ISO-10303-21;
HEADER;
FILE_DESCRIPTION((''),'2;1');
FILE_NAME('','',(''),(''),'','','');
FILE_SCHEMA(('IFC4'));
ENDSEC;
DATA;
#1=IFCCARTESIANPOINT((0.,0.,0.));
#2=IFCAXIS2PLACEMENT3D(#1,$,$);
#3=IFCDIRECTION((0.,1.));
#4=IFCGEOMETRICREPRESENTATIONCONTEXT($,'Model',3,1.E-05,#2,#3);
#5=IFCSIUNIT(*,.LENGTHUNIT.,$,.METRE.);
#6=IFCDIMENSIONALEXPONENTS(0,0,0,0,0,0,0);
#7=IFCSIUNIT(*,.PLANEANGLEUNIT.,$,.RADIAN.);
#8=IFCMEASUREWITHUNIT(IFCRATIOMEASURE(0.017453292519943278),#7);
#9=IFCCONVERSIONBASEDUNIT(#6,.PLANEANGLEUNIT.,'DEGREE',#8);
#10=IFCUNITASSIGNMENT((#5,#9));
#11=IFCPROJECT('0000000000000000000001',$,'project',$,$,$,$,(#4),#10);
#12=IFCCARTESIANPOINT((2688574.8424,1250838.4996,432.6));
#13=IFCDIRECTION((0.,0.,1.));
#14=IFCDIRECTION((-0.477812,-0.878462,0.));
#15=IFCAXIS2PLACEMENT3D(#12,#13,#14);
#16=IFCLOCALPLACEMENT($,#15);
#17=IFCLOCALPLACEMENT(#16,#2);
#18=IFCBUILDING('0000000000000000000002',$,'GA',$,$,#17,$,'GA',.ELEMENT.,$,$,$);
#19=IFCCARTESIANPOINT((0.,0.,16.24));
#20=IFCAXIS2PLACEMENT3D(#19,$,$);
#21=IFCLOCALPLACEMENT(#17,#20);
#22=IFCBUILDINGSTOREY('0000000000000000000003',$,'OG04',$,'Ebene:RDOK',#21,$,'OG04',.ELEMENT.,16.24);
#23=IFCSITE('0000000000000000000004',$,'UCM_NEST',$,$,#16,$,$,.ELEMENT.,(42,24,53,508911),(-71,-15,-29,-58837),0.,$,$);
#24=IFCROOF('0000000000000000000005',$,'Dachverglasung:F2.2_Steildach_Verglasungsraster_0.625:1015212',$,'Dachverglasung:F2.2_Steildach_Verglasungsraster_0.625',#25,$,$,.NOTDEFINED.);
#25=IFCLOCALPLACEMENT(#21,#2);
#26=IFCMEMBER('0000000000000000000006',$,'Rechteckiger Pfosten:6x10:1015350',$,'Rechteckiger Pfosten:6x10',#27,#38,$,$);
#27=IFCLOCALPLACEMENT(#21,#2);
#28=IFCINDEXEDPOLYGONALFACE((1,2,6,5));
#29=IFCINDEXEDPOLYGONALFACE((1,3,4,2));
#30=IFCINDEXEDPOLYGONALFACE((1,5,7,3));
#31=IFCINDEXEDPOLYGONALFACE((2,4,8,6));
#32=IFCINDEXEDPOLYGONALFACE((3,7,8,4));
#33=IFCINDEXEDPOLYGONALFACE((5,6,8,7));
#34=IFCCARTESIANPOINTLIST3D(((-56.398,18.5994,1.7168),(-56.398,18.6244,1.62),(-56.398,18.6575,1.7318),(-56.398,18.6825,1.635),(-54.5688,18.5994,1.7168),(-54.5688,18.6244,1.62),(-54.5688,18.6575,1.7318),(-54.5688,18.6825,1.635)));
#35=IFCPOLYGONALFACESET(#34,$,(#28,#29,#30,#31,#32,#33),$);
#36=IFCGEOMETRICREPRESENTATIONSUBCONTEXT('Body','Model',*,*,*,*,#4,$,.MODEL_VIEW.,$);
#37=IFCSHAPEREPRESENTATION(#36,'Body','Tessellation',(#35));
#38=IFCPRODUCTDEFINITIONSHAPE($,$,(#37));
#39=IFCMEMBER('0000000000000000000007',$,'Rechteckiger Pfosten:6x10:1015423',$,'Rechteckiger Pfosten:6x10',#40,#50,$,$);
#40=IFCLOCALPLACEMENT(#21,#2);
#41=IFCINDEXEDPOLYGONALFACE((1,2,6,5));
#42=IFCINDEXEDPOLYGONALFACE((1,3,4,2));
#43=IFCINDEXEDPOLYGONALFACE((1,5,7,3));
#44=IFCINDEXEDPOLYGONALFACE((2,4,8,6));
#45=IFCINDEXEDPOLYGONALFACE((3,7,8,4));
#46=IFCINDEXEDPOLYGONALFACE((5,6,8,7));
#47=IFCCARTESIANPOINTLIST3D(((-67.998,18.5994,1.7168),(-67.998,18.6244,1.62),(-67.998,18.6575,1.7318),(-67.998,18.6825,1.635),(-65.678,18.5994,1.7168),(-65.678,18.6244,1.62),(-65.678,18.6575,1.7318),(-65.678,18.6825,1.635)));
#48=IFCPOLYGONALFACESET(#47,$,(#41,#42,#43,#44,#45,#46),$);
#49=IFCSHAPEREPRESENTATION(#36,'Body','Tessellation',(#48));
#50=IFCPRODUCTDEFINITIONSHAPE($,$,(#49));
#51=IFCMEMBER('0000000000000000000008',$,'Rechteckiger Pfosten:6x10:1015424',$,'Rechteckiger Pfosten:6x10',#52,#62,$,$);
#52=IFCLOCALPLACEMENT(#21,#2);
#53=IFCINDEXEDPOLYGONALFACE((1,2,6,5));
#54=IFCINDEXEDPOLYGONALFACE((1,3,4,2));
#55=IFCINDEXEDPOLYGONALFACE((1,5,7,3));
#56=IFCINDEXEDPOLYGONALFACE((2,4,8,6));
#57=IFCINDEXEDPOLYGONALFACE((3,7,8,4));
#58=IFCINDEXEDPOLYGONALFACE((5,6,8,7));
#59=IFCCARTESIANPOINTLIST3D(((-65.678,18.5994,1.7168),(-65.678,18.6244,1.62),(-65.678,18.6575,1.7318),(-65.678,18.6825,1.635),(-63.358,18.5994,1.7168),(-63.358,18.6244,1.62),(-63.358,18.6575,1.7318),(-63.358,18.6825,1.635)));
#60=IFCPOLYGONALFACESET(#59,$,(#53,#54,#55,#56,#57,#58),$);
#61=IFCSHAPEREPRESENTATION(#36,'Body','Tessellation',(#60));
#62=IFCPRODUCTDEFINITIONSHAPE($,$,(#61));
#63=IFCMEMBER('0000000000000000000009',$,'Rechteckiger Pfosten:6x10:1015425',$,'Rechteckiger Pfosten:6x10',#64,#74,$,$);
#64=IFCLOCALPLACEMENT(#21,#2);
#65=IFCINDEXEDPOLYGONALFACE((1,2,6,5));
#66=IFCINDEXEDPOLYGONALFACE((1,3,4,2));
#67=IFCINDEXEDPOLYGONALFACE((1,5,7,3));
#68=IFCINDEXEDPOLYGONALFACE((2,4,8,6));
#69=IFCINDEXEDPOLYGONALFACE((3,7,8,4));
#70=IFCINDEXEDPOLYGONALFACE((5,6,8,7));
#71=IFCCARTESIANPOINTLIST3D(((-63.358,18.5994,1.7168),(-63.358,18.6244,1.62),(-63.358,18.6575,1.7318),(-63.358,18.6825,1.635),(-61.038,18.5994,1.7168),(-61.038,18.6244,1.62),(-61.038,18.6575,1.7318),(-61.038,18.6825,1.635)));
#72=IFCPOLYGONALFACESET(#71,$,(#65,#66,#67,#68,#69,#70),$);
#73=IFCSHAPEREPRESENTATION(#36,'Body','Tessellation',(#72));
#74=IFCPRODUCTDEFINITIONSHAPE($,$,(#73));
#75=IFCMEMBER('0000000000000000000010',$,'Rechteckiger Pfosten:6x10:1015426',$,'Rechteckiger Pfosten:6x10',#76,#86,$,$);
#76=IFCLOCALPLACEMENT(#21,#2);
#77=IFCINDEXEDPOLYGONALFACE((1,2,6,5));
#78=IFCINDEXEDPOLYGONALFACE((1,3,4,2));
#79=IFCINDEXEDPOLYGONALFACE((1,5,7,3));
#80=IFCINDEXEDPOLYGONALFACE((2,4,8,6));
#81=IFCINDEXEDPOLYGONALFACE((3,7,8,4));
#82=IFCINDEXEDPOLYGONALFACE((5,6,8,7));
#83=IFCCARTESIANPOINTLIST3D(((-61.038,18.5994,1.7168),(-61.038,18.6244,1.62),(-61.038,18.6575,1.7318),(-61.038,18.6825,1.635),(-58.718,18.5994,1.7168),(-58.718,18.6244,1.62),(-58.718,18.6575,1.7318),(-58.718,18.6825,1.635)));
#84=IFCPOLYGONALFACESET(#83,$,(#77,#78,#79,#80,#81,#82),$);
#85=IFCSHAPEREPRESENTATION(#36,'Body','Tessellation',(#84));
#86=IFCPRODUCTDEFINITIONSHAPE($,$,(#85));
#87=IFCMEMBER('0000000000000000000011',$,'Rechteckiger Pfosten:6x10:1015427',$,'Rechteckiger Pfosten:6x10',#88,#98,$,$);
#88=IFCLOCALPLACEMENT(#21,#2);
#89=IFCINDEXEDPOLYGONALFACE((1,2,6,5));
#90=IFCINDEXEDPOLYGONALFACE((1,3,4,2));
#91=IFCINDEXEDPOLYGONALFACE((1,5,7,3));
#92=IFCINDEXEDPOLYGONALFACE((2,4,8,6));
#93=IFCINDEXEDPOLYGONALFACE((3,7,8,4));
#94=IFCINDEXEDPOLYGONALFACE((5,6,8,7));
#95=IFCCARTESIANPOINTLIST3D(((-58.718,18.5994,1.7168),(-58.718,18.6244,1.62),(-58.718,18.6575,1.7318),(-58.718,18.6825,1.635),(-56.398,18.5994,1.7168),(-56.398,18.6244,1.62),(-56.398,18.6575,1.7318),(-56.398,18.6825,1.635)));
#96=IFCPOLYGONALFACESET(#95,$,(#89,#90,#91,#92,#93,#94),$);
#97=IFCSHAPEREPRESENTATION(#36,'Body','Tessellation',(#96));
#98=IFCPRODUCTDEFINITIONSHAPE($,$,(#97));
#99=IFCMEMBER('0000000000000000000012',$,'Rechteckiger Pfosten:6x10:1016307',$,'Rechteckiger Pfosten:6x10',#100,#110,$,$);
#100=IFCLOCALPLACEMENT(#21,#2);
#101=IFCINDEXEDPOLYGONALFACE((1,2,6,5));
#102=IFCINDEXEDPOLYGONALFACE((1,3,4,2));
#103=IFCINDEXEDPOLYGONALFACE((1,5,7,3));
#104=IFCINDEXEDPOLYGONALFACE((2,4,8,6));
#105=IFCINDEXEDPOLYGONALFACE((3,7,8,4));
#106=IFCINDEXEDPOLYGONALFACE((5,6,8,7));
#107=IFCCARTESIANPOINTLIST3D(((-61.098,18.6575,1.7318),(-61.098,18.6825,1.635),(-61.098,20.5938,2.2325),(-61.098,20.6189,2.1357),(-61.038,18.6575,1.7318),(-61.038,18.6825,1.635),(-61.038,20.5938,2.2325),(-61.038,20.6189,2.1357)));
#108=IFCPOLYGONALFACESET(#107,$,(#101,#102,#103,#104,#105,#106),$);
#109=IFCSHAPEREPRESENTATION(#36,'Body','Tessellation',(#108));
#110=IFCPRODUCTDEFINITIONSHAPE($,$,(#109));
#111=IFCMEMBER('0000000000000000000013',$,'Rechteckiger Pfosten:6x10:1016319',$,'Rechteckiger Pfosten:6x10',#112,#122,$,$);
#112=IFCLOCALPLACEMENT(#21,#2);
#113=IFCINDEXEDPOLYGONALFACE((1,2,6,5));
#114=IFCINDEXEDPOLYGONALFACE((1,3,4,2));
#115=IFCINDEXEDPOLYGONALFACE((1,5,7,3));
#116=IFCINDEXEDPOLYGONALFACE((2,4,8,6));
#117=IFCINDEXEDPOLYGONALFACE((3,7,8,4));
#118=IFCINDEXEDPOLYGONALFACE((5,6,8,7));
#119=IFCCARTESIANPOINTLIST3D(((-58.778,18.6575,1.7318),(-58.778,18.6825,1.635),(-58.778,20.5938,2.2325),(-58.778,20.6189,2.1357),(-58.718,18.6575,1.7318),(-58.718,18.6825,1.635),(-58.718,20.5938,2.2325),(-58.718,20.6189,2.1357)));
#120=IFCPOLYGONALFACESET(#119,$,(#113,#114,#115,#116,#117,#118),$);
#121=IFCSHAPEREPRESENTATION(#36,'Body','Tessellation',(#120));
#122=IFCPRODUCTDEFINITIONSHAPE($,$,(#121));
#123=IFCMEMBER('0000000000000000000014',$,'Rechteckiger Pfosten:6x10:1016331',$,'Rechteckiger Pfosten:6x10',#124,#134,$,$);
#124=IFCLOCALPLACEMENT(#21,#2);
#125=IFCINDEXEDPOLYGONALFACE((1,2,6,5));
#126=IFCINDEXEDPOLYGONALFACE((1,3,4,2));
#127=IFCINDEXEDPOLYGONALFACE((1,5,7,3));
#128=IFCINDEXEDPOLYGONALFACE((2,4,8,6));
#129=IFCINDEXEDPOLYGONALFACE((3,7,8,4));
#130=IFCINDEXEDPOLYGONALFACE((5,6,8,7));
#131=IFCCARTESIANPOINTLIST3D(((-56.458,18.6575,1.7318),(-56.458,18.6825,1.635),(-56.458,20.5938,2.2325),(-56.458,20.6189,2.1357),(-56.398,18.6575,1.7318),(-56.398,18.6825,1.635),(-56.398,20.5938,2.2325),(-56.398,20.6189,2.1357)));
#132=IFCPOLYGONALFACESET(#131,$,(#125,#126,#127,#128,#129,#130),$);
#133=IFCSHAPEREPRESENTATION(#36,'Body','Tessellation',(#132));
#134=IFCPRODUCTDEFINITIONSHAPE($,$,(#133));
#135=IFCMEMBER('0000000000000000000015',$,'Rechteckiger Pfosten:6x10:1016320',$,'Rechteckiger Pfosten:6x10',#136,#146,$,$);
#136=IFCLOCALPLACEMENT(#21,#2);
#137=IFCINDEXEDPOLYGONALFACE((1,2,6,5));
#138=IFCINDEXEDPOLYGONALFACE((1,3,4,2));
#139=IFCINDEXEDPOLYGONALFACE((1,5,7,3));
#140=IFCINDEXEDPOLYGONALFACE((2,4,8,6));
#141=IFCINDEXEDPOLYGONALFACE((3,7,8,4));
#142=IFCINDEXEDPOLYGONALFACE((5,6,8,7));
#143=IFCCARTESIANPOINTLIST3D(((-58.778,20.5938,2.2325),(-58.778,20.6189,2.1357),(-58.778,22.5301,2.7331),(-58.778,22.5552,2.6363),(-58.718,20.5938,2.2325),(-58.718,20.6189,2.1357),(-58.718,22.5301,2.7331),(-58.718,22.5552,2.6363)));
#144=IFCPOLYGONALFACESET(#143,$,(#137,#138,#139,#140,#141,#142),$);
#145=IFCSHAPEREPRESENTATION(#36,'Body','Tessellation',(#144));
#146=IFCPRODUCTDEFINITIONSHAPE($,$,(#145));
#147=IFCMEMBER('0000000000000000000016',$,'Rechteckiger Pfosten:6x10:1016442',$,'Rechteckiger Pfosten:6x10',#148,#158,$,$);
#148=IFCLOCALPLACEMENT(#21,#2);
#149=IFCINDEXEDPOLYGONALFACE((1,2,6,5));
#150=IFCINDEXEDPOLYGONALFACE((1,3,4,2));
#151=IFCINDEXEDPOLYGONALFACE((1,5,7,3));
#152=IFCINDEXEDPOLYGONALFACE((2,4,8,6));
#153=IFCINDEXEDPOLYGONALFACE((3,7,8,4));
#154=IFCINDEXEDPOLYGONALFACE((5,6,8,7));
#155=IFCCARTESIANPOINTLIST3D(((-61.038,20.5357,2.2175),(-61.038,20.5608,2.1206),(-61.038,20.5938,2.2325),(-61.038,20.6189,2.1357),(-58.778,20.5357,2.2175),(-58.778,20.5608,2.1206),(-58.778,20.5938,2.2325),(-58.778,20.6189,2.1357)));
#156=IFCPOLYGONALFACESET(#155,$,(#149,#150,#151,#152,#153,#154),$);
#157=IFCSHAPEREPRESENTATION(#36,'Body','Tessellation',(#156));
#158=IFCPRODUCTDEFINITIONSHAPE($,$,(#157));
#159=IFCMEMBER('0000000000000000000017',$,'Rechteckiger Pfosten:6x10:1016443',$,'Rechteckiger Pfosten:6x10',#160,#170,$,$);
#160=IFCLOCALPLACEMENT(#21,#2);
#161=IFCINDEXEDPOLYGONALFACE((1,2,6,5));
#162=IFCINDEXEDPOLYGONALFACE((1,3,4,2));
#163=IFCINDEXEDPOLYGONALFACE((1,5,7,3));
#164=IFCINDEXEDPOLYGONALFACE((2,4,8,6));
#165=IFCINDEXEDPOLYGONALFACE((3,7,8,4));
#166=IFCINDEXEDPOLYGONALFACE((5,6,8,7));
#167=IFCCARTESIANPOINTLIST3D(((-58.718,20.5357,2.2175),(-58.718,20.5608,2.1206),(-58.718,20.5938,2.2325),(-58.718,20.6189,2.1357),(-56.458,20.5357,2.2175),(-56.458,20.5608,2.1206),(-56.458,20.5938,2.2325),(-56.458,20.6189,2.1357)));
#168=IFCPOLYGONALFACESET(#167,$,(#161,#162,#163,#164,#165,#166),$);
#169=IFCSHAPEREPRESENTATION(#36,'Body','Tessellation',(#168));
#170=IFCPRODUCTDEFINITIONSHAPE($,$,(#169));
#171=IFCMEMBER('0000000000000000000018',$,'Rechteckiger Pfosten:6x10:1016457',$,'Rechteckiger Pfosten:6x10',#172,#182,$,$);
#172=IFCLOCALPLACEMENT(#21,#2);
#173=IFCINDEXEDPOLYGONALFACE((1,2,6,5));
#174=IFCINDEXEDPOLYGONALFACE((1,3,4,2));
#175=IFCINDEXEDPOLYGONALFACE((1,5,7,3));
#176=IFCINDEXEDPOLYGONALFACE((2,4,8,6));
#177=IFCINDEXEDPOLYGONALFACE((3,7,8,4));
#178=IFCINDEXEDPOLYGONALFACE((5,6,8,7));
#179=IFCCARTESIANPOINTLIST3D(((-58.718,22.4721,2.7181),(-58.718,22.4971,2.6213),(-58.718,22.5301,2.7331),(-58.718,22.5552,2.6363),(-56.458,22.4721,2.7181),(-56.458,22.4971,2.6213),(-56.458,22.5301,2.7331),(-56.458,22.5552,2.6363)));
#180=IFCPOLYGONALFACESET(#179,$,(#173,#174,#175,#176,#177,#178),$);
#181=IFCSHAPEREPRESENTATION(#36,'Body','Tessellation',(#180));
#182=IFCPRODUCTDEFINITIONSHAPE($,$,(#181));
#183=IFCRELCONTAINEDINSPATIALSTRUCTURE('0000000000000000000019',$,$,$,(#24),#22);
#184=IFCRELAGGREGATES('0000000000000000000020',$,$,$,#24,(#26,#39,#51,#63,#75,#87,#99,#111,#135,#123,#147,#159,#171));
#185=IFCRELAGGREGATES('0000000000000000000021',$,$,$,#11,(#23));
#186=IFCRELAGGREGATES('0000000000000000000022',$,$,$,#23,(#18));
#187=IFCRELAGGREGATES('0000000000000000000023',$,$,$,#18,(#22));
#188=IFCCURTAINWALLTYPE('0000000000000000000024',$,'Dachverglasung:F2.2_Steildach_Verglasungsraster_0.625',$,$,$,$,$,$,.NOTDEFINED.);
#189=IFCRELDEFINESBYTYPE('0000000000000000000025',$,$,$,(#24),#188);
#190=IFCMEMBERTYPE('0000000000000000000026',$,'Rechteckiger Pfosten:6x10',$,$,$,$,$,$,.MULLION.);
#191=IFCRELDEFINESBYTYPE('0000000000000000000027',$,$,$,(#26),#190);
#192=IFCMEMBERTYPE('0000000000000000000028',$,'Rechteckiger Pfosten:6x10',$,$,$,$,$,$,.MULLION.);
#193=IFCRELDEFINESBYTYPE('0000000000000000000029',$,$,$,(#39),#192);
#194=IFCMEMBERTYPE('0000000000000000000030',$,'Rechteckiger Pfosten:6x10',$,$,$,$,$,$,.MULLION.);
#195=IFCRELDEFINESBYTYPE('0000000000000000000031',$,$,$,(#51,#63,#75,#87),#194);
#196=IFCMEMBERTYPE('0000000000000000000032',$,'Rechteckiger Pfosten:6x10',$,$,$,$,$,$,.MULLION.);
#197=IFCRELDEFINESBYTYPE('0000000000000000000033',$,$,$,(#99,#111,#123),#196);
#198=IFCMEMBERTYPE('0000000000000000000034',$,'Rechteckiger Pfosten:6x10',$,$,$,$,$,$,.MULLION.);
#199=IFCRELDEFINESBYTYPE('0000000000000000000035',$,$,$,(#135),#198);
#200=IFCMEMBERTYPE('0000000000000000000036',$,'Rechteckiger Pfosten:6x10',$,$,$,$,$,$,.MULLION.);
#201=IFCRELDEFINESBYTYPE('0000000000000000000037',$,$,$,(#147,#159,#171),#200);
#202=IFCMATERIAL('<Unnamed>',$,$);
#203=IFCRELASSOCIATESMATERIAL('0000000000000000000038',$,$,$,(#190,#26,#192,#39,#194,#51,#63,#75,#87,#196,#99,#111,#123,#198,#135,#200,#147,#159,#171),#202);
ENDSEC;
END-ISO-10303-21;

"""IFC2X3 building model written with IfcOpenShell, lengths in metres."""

from ifc_helpers import new_model, entity, si_unit, converted_unit, direction, frame, origin, origin_2d_with_axis, place, context, subcontext, project, spatial, rectangle, extrude, source, transform, mapped, material, type_object, type_shapes, element, aggregate, save


model = new_model("IFC2X3")

# Units and contexts
model_context = context("Model", 3, precision=1e-05, world=origin(), true_north=direction((0.0, 1.0)))
body_context = subcontext(model_context, "Body", "Model", "MODEL_VIEW")
ifc_project = project(units=[si_unit("LENGTHUNIT", "METRE"), converted_unit("PLANEANGLEUNIT", "DEGREE", entity("IfcRatioMeasure", 0.017453292519943278), si_unit("PLANEANGLEUNIT", "RADIAN"), dimensions=[0, 0, 0, 0, 0, 0, 0])], contexts=[model_context])

# Site, building, storey
site_placement = place(None, frame((2688574.8424, 1250838.4996, 432.6), z_axis=(0.0, 0.0, 1.0), x_axis=(-0.477812, -0.878462, 0.0)))
site = spatial("IfcSite", under=ifc_project, at=site_placement, Name="UCM_NEST", CompositionType="ELEMENT", RefLatitude=(42, 24, 53, 508911), RefLongitude=(-71, -15, -29, -58837), RefElevation=0.0)
building_placement = place(site_placement, origin())
building = spatial("IfcBuilding", under=site, at=building_placement, Name="GA", LongName="GA", CompositionType="ELEMENT")
storey_placement = place(building_placement, frame((0.0, 0.0, 16.24)))
storey = spatial("IfcBuildingStorey", under=building, at=storey_placement, Name="OG04", ObjectType="Ebene:RDOK", LongName="OG04", CompositionType="ELEMENT", Elevation=16.24)

# Roof, members
curtain_wall_type = type_object("IfcCurtainWallType", Name="Dachverglasung:F2.2_Steildach_Verglasungsraster_0.625", PredefinedType="NOTDEFINED")
roof_placement = place(storey_placement, frame((0.0, 0.0, -16.24)))
roof = element("IfcRoof", 1, at=roof_placement, inside=storey, type_object=curtain_wall_type, Name="Dachverglasung:F2.2_Steildach_Verglasungsraster_0.625:1015212", ObjectType="Dachverglasung:F2.2_Steildach_Verglasungsraster_0.625", ShapeType="NOTDEFINED")
ifc_material_1 = material(Name="<Unnamed>")
member_type_1 = type_object("IfcMemberType", Name="Rechteckiger Pfosten:6x10", PredefinedType="MULLION", material=ifc_material_1)
shared_shape_1 = source(origin(), body_context, "Body", "SweptSolid", [
    extrude(rectangle(XDim=0.1, YDim=0.06, at=origin_2d_with_axis()), frame((-0.03, -0.05, -1.8292), z_axis=(0.0, 0.0, 1.0), x_axis=(0.0, -1.0, 0.0)), (0.0, 0.0, 1.0), 1.8292),
])
type_shapes(member_type_1, [shared_shape_1])
member_1_placement = place(roof_placement, frame((-54.5688, 18.6244, 17.86), z_axis=(1.0, 0.0, 0.0), x_axis=(0.0, -0.968163, -0.250322)))
member_1 = element("IfcMember", 2, at=member_1_placement, type_object=member_type_1, material=ifc_material_1, Name="Rechteckiger Pfosten:6x10:1015350", ObjectType="Rechteckiger Pfosten:6x10", context=body_context, shape_type="MappedRepresentation", body=[
    mapped(shared_shape_1, transform((0.0, 0.0, 0.0), scale=1.0)),
])
member_type_2 = type_object("IfcMemberType", Name="Rechteckiger Pfosten:6x10", PredefinedType="MULLION", material=ifc_material_1)
shared_shape_2 = source(origin(), body_context, "Body", "SweptSolid", [
    extrude(rectangle(XDim=0.1, YDim=0.06, at=origin_2d_with_axis()), frame((-0.03, -0.05, -2.32), z_axis=(0.0, 0.0, 1.0), x_axis=(0.0, -1.0, 0.0)), (0.0, 0.0, 1.0), 2.32),
])
type_shapes(member_type_2, [shared_shape_2])
member_2_placement = place(roof_placement, frame((-65.678, 18.6244, 17.86), z_axis=(1.0, 0.0, 0.0), x_axis=(0.0, -0.968163, -0.250322)))
member_2 = element("IfcMember", 3, at=member_2_placement, type_object=member_type_2, material=ifc_material_1, Name="Rechteckiger Pfosten:6x10:1015423", ObjectType="Rechteckiger Pfosten:6x10", context=body_context, shape_type="MappedRepresentation", body=[
    mapped(shared_shape_2, transform((0.0, 0.0, 0.0), scale=1.0)),
])
member_type_3 = type_object("IfcMemberType", Name="Rechteckiger Pfosten:6x10", PredefinedType="MULLION", material=ifc_material_1)
shared_shape_3 = source(origin(), body_context, "Body", "SweptSolid", [
    extrude(rectangle(XDim=0.1, YDim=0.06, at=origin_2d_with_axis()), frame((-0.03, -0.05, -2.32), z_axis=(0.0, 0.0, 1.0), x_axis=(0.0, -1.0, 0.0)), (0.0, 0.0, 1.0), 2.32),
])
type_shapes(member_type_3, [shared_shape_3])
member_3_placement = place(roof_placement, frame((-63.358, 18.6244, 17.86), z_axis=(1.0, 0.0, 0.0), x_axis=(0.0, -0.968163, -0.250322)))
member_3 = element("IfcMember", 4, at=member_3_placement, type_object=member_type_3, material=ifc_material_1, Name="Rechteckiger Pfosten:6x10:1015424", ObjectType="Rechteckiger Pfosten:6x10", context=body_context, shape_type="MappedRepresentation", body=[
    mapped(shared_shape_3, transform((0.0, 0.0, 0.0), scale=1.0)),
])
member_4_placement = place(roof_placement, frame((-61.038, 18.6244, 17.86), z_axis=(1.0, 0.0, 0.0), x_axis=(0.0, -0.968163, -0.250322)))
member_4 = element("IfcMember", 5, at=member_4_placement, type_object=member_type_3, material=ifc_material_1, Name="Rechteckiger Pfosten:6x10:1015425", ObjectType="Rechteckiger Pfosten:6x10", context=body_context, shape_type="MappedRepresentation", body=[
    mapped(shared_shape_3, transform((0.0, 0.0, 0.0), scale=1.0)),
])
member_5_placement = place(roof_placement, frame((-58.718, 18.6244, 17.86), z_axis=(1.0, 0.0, 0.0), x_axis=(0.0, -0.968163, -0.250322)))
member_5 = element("IfcMember", 6, at=member_5_placement, type_object=member_type_3, material=ifc_material_1, Name="Rechteckiger Pfosten:6x10:1015426", ObjectType="Rechteckiger Pfosten:6x10", context=body_context, shape_type="MappedRepresentation", body=[
    mapped(shared_shape_3, transform((0.0, 0.0, 0.0), scale=1.0)),
])
member_6_placement = place(roof_placement, frame((-56.398, 18.6244, 17.86), z_axis=(1.0, 0.0, 0.0), x_axis=(0.0, -0.968163, -0.250322)))
member_6 = element("IfcMember", 7, at=member_6_placement, type_object=member_type_3, material=ifc_material_1, Name="Rechteckiger Pfosten:6x10:1015427", ObjectType="Rechteckiger Pfosten:6x10", context=body_context, shape_type="MappedRepresentation", body=[
    mapped(shared_shape_3, transform((0.0, 0.0, 0.0), scale=1.0)),
])
member_type_4 = type_object("IfcMemberType", Name="Rechteckiger Pfosten:6x10", PredefinedType="MULLION", material=ifc_material_1)
shared_shape_4 = source(origin(), body_context, "Body", "SweptSolid", [
    extrude(rectangle(XDim=0.1, YDim=0.06, at=origin_2d_with_axis()), frame((-0.03, -0.05, -2.0), z_axis=(0.0, 0.0, 1.0), x_axis=(0.0, -1.0, 0.0)), (0.0, 0.0, 1.0), 2.0),
])
type_shapes(member_type_4, [shared_shape_4])
member_7_placement = place(roof_placement, frame((-61.038, 20.6189, 18.3757), z_axis=(0.0, 0.968163, 0.250322), x_axis=(1.0, 0.0, 0.0)))
member_7 = element("IfcMember", 8, at=member_7_placement, type_object=member_type_4, material=ifc_material_1, Name="Rechteckiger Pfosten:6x10:1016307", ObjectType="Rechteckiger Pfosten:6x10", context=body_context, shape_type="MappedRepresentation", body=[
    mapped(shared_shape_4, transform((0.0, 0.0, 0.0), scale=1.0)),
])
member_8_placement = place(roof_placement, frame((-58.718, 20.6189, 18.3757), z_axis=(0.0, 0.968163, 0.250322), x_axis=(1.0, 0.0, 0.0)))
member_8 = element("IfcMember", 9, at=member_8_placement, type_object=member_type_4, material=ifc_material_1, Name="Rechteckiger Pfosten:6x10:1016319", ObjectType="Rechteckiger Pfosten:6x10", context=body_context, shape_type="MappedRepresentation", body=[
    mapped(shared_shape_4, transform((0.0, 0.0, 0.0), scale=1.0)),
])
member_9_placement = place(roof_placement, frame((-56.398, 20.6189, 18.3757), z_axis=(0.0, 0.968163, 0.250322), x_axis=(1.0, 0.0, 0.0)))
member_9 = element("IfcMember", 10, at=member_9_placement, type_object=member_type_4, material=ifc_material_1, Name="Rechteckiger Pfosten:6x10:1016331", ObjectType="Rechteckiger Pfosten:6x10", context=body_context, shape_type="MappedRepresentation", body=[
    mapped(shared_shape_4, transform((0.0, 0.0, 0.0), scale=1.0)),
])
member_type_5 = type_object("IfcMemberType", Name="Rechteckiger Pfosten:6x10", PredefinedType="MULLION", material=ifc_material_1)
shared_shape_5 = source(origin(), body_context, "Body", "SweptSolid", [
    extrude(rectangle(XDim=0.1, YDim=0.06, at=origin_2d_with_axis()), frame((-0.03, -0.05, -2.0), z_axis=(0.0, 0.0, 1.0), x_axis=(0.0, -1.0, 0.0)), (0.0, 0.0, 1.0), 2.0),
])
type_shapes(member_type_5, [shared_shape_5])
member_10_placement = place(roof_placement, frame((-58.718, 22.5552, 18.8763), z_axis=(0.0, 0.968163, 0.250322), x_axis=(1.0, 0.0, 0.0)))
member_10 = element("IfcMember", 11, at=member_10_placement, type_object=member_type_5, material=ifc_material_1, Name="Rechteckiger Pfosten:6x10:1016320", ObjectType="Rechteckiger Pfosten:6x10", context=body_context, shape_type="MappedRepresentation", body=[
    mapped(shared_shape_5, transform((0.0, 0.0, 0.0), scale=1.0)),
])
member_type_6 = type_object("IfcMemberType", Name="Rechteckiger Pfosten:6x10", PredefinedType="MULLION", material=ifc_material_1)
shared_shape_6 = source(origin(), body_context, "Body", "SweptSolid", [
    extrude(rectangle(XDim=0.1, YDim=0.06, at=origin_2d_with_axis()), frame((-0.03, -0.05, -2.26), z_axis=(0.0, 0.0, 1.0), x_axis=(0.0, -1.0, 0.0)), (0.0, 0.0, 1.0), 2.26),
])
type_shapes(member_type_6, [shared_shape_6])
member_11_placement = place(roof_placement, frame((-61.038, 20.6189, 18.3757), z_axis=(-1.0, 0.0, 0.0), x_axis=(0.0, 0.968163, 0.250322)))
member_11 = element("IfcMember", 12, at=member_11_placement, type_object=member_type_6, material=ifc_material_1, Name="Rechteckiger Pfosten:6x10:1016442", ObjectType="Rechteckiger Pfosten:6x10", context=body_context, shape_type="MappedRepresentation", body=[
    mapped(shared_shape_6, transform((0.0, 0.0, 0.0), scale=1.0)),
])
member_12_placement = place(roof_placement, frame((-58.718, 20.6189, 18.3757), z_axis=(-1.0, 0.0, 0.0), x_axis=(0.0, 0.968163, 0.250322)))
member_12 = element("IfcMember", 13, at=member_12_placement, type_object=member_type_6, material=ifc_material_1, Name="Rechteckiger Pfosten:6x10:1016443", ObjectType="Rechteckiger Pfosten:6x10", context=body_context, shape_type="MappedRepresentation", body=[
    mapped(shared_shape_6, transform((0.0, 0.0, 0.0), scale=1.0)),
])
member_13_placement = place(roof_placement, frame((-58.718, 22.5552, 18.8763), z_axis=(-1.0, 0.0, 0.0), x_axis=(0.0, 0.968163, 0.250322)))
member_13 = element("IfcMember", 14, at=member_13_placement, type_object=member_type_6, material=ifc_material_1, Name="Rechteckiger Pfosten:6x10:1016457", ObjectType="Rechteckiger Pfosten:6x10", context=body_context, shape_type="MappedRepresentation", body=[
    mapped(shared_shape_6, transform((0.0, 0.0, 0.0), scale=1.0)),
])
aggregate(roof, [member_1, member_2, member_3, member_4, member_5, member_6, member_7, member_8, member_10, member_9, member_11, member_12, member_13])

save(model, "model.ifc")
